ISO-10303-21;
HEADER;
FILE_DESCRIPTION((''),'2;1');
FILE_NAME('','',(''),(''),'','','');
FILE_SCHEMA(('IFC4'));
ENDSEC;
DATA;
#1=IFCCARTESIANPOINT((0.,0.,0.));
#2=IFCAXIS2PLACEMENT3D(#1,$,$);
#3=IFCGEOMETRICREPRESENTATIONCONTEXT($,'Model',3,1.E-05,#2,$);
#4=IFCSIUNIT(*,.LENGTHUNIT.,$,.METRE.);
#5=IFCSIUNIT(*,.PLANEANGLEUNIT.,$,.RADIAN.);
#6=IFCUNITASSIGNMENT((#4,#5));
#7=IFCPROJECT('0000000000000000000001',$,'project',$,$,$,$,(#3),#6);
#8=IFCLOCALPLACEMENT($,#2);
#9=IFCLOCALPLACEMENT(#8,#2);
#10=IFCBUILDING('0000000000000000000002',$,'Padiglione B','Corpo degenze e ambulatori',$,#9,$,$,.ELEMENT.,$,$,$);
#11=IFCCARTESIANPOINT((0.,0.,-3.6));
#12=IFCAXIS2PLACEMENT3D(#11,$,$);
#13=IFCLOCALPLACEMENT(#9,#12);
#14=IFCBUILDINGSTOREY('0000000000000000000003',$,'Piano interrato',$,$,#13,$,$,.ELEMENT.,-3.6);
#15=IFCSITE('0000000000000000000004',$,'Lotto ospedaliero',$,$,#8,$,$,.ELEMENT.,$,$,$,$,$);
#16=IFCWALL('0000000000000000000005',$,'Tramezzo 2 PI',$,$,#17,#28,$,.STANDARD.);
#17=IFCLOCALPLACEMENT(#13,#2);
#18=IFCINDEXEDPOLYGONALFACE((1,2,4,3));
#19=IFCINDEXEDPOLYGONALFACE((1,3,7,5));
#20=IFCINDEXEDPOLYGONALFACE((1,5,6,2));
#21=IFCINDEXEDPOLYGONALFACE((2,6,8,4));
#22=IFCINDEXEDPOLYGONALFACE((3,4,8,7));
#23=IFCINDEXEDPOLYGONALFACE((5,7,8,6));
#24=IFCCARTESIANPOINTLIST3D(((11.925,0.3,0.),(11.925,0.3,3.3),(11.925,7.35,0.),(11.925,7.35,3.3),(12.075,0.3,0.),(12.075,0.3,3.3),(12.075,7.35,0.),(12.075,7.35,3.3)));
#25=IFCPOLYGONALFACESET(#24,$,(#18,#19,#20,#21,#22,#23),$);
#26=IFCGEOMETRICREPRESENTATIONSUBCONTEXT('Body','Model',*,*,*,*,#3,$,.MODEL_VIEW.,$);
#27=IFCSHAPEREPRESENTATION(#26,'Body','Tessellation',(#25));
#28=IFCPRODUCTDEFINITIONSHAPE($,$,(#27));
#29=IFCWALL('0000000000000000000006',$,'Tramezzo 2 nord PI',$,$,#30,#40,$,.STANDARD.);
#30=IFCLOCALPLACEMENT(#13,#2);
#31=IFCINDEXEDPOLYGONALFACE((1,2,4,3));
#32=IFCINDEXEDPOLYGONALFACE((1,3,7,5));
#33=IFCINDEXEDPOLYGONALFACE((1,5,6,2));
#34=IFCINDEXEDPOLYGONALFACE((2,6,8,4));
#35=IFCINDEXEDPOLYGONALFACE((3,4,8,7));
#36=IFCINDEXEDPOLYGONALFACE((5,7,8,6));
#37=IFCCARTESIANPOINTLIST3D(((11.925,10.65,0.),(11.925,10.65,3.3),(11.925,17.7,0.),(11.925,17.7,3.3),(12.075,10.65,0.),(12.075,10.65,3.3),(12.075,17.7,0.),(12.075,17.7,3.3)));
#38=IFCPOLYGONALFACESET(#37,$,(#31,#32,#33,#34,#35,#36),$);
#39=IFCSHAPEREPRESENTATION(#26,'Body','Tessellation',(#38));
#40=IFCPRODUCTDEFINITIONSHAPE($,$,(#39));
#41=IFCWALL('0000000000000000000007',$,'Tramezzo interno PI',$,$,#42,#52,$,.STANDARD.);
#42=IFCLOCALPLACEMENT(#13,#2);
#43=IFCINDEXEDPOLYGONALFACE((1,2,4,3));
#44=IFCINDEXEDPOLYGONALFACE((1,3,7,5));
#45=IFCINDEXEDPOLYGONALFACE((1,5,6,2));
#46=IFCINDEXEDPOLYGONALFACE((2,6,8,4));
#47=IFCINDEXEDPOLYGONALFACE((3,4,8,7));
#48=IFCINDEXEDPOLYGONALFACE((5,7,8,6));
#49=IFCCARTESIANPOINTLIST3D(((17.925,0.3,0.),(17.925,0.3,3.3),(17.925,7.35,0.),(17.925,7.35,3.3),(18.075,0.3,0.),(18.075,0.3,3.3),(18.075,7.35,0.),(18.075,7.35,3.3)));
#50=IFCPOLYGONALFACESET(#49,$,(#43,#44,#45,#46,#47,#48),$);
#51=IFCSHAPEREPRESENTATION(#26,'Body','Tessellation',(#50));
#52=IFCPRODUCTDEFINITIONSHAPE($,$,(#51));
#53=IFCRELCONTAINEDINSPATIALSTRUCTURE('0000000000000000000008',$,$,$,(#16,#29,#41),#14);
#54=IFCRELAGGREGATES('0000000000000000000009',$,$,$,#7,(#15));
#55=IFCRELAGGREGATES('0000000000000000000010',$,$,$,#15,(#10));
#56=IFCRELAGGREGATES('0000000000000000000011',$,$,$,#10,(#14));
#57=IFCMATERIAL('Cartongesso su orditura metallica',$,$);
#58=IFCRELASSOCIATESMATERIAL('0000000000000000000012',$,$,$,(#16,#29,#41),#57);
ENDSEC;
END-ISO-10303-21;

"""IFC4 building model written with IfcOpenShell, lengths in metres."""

from ifc_helpers import new_model, si_unit, frame, frame_2d, origin, place, context, subcontext, project, spatial, rectangle, extrude, material, element, save


model = new_model("IFC4")

# Units and contexts
model_context = context("Model", 3, precision=1e-05, world=origin())
body_context = subcontext(model_context, "Body", "Model", "MODEL_VIEW")
ifc_project = project(units=[si_unit("LENGTHUNIT", "METRE"), si_unit("PLANEANGLEUNIT", "RADIAN")], contexts=[model_context])

# Site, building, storey
site_placement = place(None, origin())
site = spatial("IfcSite", under=ifc_project, at=site_placement, Name="Lotto ospedaliero", CompositionType="ELEMENT")
building_placement = place(site_placement, origin())
building = spatial("IfcBuilding", under=site, at=building_placement, Name="Padiglione B", Description="Corpo degenze e ambulatori", CompositionType="ELEMENT")
storey_placement = place(building_placement, frame((0.0, 0.0, -3.6)))
storey = spatial("IfcBuildingStorey", under=building, at=storey_placement, Name="Piano interrato", CompositionType="ELEMENT", Elevation=-3.6)

# Walls
ifc_material_1 = material(Name="Cartongesso su orditura metallica")
for number, where, name in (
    (1, (11.925, 0.3, 0.0), "Tramezzo 2 PI"),
    (2, (11.925, 10.65, 0.0), "Tramezzo 2 nord PI"),
    (3, (17.925, 0.3, 0.0), "Tramezzo interno PI"),
):
    element("IfcWall", number, at=place(storey_placement, frame(where)), inside=storey, material=ifc_material_1, Name=name, PredefinedType="STANDARD", context=body_context, shape_type="SweptSolid", body=[
        extrude(rectangle(XDim=0.15, YDim=7.05, at=frame_2d((0.075, 3.525))), origin(), (0.0, 0.0, 1.0), 3.3),
    ])

save(model, "model.ifc")
